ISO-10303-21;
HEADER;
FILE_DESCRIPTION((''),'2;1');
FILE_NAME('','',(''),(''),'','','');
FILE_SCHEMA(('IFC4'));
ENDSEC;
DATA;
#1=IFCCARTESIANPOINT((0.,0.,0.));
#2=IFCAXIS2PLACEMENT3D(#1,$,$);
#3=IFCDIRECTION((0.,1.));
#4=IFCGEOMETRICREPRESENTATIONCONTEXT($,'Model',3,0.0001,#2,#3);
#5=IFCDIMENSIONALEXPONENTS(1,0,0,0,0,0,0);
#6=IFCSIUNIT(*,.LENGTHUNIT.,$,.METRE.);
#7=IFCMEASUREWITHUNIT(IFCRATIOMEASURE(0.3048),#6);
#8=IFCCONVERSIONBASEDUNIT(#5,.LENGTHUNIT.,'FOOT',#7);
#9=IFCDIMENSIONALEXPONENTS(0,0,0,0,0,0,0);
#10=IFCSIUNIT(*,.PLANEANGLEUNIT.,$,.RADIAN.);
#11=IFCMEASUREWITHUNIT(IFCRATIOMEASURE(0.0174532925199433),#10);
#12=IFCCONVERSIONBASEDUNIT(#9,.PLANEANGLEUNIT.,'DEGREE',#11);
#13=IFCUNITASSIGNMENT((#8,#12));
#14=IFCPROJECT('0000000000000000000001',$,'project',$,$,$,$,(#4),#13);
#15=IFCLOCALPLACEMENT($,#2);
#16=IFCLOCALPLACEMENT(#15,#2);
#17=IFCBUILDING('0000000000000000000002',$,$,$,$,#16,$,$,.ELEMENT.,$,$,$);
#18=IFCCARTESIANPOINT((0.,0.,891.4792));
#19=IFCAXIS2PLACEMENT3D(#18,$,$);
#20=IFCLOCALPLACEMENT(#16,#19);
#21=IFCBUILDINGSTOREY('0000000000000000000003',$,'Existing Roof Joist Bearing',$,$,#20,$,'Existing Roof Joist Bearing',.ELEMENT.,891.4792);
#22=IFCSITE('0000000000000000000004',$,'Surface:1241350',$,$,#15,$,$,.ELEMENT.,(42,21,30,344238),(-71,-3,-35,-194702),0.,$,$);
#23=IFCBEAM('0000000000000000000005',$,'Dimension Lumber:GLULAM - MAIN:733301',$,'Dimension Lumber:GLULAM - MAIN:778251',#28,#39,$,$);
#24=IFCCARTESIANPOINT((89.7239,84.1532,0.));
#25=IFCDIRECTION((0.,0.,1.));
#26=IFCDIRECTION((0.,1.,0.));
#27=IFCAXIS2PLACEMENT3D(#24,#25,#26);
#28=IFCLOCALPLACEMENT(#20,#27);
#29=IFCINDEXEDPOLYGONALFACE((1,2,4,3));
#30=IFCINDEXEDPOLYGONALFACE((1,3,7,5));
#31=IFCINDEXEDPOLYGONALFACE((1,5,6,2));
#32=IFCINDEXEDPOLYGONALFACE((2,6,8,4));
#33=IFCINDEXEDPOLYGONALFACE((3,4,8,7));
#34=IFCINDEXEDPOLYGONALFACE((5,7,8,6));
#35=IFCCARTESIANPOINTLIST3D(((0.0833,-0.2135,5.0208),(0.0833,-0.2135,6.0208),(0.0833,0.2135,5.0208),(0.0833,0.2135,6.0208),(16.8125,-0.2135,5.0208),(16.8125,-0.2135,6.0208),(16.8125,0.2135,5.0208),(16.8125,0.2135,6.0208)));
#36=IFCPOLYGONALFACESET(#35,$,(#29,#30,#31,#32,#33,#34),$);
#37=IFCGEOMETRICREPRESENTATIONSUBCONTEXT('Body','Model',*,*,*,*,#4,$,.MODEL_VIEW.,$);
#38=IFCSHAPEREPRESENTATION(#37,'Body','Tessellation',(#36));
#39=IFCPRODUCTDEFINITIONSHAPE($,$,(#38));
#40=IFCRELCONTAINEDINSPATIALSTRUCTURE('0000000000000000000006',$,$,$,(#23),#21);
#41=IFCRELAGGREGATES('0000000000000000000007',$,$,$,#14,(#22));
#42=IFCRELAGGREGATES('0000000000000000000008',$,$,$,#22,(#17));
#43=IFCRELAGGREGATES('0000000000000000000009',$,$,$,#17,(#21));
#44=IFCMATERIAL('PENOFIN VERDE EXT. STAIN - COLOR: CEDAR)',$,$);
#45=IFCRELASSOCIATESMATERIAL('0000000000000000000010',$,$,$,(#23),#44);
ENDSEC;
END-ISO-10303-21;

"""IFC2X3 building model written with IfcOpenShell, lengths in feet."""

from ifc_helpers import new_model, entity, si_unit, converted_unit, direction, frame, frame_2d, origin, place, context, subcontext, project, spatial, rectangle, extrude, material, element, save


model = new_model("IFC2X3")

# Units and contexts
model_context = context("Model", 3, precision=0.0001, world=origin(), true_north=direction((0.0, 1.0)))
body_context = subcontext(model_context, "Body", "Model", "MODEL_VIEW")
ifc_project = project(units=[converted_unit("LENGTHUNIT", "FOOT", entity("IfcRatioMeasure", 0.3048), si_unit("LENGTHUNIT", "METRE"), dimensions=[1, 0, 0, 0, 0, 0, 0]), converted_unit("PLANEANGLEUNIT", "DEGREE", entity("IfcRatioMeasure", 0.0174532925199433), si_unit("PLANEANGLEUNIT", "RADIAN"), dimensions=[0, 0, 0, 0, 0, 0, 0])], contexts=[model_context])

# Site, building, storey
site_placement = place(None, origin())
site = spatial("IfcSite", under=ifc_project, at=site_placement, Name="Surface:1241350", CompositionType="ELEMENT", RefLatitude=(42, 21, 30, 344238), RefLongitude=(-71, -3, -35, -194702), RefElevation=0.0)
building_placement = place(site_placement, origin())
building = spatial("IfcBuilding", under=site, at=building_placement, CompositionType="ELEMENT")
storey_placement = place(building_placement, frame((0.0, 0.0, 891.4792)))
storey = spatial("IfcBuildingStorey", under=building, at=storey_placement, Name="Existing Roof Joist Bearing", LongName="Existing Roof Joist Bearing", CompositionType="ELEMENT", Elevation=891.4792)

# Beam
ifc_material_1 = material(Name="PENOFIN VERDE EXT. STAIN - COLOR: CEDAR)")
beam_1_placement = place(storey_placement, frame((89.7239, 84.1532, 0.0), z_axis=(0.0, 0.0, 1.0), x_axis=(0.0, 1.0, 0.0)))
element("IfcBeam", 1, at=beam_1_placement, inside=storey, material=ifc_material_1, Name="Dimension Lumber:GLULAM - MAIN:733301", ObjectType="Dimension Lumber:GLULAM - MAIN:778251", context=body_context, shape_type="SweptSolid", body=[
    extrude(rectangle(XDim=1.0, YDim=0.4271, at=frame_2d((0.0, 0.0), x_axis=(1.0, 0.0))), frame((0.0833, 0.0, 5.5208), z_axis=(1.0, 0.0, 0.0), x_axis=(0.0, 0.0, -1.0)), (0.0, 0.0, 1.0), 16.7292),
])

save(model, "model.ifc")
